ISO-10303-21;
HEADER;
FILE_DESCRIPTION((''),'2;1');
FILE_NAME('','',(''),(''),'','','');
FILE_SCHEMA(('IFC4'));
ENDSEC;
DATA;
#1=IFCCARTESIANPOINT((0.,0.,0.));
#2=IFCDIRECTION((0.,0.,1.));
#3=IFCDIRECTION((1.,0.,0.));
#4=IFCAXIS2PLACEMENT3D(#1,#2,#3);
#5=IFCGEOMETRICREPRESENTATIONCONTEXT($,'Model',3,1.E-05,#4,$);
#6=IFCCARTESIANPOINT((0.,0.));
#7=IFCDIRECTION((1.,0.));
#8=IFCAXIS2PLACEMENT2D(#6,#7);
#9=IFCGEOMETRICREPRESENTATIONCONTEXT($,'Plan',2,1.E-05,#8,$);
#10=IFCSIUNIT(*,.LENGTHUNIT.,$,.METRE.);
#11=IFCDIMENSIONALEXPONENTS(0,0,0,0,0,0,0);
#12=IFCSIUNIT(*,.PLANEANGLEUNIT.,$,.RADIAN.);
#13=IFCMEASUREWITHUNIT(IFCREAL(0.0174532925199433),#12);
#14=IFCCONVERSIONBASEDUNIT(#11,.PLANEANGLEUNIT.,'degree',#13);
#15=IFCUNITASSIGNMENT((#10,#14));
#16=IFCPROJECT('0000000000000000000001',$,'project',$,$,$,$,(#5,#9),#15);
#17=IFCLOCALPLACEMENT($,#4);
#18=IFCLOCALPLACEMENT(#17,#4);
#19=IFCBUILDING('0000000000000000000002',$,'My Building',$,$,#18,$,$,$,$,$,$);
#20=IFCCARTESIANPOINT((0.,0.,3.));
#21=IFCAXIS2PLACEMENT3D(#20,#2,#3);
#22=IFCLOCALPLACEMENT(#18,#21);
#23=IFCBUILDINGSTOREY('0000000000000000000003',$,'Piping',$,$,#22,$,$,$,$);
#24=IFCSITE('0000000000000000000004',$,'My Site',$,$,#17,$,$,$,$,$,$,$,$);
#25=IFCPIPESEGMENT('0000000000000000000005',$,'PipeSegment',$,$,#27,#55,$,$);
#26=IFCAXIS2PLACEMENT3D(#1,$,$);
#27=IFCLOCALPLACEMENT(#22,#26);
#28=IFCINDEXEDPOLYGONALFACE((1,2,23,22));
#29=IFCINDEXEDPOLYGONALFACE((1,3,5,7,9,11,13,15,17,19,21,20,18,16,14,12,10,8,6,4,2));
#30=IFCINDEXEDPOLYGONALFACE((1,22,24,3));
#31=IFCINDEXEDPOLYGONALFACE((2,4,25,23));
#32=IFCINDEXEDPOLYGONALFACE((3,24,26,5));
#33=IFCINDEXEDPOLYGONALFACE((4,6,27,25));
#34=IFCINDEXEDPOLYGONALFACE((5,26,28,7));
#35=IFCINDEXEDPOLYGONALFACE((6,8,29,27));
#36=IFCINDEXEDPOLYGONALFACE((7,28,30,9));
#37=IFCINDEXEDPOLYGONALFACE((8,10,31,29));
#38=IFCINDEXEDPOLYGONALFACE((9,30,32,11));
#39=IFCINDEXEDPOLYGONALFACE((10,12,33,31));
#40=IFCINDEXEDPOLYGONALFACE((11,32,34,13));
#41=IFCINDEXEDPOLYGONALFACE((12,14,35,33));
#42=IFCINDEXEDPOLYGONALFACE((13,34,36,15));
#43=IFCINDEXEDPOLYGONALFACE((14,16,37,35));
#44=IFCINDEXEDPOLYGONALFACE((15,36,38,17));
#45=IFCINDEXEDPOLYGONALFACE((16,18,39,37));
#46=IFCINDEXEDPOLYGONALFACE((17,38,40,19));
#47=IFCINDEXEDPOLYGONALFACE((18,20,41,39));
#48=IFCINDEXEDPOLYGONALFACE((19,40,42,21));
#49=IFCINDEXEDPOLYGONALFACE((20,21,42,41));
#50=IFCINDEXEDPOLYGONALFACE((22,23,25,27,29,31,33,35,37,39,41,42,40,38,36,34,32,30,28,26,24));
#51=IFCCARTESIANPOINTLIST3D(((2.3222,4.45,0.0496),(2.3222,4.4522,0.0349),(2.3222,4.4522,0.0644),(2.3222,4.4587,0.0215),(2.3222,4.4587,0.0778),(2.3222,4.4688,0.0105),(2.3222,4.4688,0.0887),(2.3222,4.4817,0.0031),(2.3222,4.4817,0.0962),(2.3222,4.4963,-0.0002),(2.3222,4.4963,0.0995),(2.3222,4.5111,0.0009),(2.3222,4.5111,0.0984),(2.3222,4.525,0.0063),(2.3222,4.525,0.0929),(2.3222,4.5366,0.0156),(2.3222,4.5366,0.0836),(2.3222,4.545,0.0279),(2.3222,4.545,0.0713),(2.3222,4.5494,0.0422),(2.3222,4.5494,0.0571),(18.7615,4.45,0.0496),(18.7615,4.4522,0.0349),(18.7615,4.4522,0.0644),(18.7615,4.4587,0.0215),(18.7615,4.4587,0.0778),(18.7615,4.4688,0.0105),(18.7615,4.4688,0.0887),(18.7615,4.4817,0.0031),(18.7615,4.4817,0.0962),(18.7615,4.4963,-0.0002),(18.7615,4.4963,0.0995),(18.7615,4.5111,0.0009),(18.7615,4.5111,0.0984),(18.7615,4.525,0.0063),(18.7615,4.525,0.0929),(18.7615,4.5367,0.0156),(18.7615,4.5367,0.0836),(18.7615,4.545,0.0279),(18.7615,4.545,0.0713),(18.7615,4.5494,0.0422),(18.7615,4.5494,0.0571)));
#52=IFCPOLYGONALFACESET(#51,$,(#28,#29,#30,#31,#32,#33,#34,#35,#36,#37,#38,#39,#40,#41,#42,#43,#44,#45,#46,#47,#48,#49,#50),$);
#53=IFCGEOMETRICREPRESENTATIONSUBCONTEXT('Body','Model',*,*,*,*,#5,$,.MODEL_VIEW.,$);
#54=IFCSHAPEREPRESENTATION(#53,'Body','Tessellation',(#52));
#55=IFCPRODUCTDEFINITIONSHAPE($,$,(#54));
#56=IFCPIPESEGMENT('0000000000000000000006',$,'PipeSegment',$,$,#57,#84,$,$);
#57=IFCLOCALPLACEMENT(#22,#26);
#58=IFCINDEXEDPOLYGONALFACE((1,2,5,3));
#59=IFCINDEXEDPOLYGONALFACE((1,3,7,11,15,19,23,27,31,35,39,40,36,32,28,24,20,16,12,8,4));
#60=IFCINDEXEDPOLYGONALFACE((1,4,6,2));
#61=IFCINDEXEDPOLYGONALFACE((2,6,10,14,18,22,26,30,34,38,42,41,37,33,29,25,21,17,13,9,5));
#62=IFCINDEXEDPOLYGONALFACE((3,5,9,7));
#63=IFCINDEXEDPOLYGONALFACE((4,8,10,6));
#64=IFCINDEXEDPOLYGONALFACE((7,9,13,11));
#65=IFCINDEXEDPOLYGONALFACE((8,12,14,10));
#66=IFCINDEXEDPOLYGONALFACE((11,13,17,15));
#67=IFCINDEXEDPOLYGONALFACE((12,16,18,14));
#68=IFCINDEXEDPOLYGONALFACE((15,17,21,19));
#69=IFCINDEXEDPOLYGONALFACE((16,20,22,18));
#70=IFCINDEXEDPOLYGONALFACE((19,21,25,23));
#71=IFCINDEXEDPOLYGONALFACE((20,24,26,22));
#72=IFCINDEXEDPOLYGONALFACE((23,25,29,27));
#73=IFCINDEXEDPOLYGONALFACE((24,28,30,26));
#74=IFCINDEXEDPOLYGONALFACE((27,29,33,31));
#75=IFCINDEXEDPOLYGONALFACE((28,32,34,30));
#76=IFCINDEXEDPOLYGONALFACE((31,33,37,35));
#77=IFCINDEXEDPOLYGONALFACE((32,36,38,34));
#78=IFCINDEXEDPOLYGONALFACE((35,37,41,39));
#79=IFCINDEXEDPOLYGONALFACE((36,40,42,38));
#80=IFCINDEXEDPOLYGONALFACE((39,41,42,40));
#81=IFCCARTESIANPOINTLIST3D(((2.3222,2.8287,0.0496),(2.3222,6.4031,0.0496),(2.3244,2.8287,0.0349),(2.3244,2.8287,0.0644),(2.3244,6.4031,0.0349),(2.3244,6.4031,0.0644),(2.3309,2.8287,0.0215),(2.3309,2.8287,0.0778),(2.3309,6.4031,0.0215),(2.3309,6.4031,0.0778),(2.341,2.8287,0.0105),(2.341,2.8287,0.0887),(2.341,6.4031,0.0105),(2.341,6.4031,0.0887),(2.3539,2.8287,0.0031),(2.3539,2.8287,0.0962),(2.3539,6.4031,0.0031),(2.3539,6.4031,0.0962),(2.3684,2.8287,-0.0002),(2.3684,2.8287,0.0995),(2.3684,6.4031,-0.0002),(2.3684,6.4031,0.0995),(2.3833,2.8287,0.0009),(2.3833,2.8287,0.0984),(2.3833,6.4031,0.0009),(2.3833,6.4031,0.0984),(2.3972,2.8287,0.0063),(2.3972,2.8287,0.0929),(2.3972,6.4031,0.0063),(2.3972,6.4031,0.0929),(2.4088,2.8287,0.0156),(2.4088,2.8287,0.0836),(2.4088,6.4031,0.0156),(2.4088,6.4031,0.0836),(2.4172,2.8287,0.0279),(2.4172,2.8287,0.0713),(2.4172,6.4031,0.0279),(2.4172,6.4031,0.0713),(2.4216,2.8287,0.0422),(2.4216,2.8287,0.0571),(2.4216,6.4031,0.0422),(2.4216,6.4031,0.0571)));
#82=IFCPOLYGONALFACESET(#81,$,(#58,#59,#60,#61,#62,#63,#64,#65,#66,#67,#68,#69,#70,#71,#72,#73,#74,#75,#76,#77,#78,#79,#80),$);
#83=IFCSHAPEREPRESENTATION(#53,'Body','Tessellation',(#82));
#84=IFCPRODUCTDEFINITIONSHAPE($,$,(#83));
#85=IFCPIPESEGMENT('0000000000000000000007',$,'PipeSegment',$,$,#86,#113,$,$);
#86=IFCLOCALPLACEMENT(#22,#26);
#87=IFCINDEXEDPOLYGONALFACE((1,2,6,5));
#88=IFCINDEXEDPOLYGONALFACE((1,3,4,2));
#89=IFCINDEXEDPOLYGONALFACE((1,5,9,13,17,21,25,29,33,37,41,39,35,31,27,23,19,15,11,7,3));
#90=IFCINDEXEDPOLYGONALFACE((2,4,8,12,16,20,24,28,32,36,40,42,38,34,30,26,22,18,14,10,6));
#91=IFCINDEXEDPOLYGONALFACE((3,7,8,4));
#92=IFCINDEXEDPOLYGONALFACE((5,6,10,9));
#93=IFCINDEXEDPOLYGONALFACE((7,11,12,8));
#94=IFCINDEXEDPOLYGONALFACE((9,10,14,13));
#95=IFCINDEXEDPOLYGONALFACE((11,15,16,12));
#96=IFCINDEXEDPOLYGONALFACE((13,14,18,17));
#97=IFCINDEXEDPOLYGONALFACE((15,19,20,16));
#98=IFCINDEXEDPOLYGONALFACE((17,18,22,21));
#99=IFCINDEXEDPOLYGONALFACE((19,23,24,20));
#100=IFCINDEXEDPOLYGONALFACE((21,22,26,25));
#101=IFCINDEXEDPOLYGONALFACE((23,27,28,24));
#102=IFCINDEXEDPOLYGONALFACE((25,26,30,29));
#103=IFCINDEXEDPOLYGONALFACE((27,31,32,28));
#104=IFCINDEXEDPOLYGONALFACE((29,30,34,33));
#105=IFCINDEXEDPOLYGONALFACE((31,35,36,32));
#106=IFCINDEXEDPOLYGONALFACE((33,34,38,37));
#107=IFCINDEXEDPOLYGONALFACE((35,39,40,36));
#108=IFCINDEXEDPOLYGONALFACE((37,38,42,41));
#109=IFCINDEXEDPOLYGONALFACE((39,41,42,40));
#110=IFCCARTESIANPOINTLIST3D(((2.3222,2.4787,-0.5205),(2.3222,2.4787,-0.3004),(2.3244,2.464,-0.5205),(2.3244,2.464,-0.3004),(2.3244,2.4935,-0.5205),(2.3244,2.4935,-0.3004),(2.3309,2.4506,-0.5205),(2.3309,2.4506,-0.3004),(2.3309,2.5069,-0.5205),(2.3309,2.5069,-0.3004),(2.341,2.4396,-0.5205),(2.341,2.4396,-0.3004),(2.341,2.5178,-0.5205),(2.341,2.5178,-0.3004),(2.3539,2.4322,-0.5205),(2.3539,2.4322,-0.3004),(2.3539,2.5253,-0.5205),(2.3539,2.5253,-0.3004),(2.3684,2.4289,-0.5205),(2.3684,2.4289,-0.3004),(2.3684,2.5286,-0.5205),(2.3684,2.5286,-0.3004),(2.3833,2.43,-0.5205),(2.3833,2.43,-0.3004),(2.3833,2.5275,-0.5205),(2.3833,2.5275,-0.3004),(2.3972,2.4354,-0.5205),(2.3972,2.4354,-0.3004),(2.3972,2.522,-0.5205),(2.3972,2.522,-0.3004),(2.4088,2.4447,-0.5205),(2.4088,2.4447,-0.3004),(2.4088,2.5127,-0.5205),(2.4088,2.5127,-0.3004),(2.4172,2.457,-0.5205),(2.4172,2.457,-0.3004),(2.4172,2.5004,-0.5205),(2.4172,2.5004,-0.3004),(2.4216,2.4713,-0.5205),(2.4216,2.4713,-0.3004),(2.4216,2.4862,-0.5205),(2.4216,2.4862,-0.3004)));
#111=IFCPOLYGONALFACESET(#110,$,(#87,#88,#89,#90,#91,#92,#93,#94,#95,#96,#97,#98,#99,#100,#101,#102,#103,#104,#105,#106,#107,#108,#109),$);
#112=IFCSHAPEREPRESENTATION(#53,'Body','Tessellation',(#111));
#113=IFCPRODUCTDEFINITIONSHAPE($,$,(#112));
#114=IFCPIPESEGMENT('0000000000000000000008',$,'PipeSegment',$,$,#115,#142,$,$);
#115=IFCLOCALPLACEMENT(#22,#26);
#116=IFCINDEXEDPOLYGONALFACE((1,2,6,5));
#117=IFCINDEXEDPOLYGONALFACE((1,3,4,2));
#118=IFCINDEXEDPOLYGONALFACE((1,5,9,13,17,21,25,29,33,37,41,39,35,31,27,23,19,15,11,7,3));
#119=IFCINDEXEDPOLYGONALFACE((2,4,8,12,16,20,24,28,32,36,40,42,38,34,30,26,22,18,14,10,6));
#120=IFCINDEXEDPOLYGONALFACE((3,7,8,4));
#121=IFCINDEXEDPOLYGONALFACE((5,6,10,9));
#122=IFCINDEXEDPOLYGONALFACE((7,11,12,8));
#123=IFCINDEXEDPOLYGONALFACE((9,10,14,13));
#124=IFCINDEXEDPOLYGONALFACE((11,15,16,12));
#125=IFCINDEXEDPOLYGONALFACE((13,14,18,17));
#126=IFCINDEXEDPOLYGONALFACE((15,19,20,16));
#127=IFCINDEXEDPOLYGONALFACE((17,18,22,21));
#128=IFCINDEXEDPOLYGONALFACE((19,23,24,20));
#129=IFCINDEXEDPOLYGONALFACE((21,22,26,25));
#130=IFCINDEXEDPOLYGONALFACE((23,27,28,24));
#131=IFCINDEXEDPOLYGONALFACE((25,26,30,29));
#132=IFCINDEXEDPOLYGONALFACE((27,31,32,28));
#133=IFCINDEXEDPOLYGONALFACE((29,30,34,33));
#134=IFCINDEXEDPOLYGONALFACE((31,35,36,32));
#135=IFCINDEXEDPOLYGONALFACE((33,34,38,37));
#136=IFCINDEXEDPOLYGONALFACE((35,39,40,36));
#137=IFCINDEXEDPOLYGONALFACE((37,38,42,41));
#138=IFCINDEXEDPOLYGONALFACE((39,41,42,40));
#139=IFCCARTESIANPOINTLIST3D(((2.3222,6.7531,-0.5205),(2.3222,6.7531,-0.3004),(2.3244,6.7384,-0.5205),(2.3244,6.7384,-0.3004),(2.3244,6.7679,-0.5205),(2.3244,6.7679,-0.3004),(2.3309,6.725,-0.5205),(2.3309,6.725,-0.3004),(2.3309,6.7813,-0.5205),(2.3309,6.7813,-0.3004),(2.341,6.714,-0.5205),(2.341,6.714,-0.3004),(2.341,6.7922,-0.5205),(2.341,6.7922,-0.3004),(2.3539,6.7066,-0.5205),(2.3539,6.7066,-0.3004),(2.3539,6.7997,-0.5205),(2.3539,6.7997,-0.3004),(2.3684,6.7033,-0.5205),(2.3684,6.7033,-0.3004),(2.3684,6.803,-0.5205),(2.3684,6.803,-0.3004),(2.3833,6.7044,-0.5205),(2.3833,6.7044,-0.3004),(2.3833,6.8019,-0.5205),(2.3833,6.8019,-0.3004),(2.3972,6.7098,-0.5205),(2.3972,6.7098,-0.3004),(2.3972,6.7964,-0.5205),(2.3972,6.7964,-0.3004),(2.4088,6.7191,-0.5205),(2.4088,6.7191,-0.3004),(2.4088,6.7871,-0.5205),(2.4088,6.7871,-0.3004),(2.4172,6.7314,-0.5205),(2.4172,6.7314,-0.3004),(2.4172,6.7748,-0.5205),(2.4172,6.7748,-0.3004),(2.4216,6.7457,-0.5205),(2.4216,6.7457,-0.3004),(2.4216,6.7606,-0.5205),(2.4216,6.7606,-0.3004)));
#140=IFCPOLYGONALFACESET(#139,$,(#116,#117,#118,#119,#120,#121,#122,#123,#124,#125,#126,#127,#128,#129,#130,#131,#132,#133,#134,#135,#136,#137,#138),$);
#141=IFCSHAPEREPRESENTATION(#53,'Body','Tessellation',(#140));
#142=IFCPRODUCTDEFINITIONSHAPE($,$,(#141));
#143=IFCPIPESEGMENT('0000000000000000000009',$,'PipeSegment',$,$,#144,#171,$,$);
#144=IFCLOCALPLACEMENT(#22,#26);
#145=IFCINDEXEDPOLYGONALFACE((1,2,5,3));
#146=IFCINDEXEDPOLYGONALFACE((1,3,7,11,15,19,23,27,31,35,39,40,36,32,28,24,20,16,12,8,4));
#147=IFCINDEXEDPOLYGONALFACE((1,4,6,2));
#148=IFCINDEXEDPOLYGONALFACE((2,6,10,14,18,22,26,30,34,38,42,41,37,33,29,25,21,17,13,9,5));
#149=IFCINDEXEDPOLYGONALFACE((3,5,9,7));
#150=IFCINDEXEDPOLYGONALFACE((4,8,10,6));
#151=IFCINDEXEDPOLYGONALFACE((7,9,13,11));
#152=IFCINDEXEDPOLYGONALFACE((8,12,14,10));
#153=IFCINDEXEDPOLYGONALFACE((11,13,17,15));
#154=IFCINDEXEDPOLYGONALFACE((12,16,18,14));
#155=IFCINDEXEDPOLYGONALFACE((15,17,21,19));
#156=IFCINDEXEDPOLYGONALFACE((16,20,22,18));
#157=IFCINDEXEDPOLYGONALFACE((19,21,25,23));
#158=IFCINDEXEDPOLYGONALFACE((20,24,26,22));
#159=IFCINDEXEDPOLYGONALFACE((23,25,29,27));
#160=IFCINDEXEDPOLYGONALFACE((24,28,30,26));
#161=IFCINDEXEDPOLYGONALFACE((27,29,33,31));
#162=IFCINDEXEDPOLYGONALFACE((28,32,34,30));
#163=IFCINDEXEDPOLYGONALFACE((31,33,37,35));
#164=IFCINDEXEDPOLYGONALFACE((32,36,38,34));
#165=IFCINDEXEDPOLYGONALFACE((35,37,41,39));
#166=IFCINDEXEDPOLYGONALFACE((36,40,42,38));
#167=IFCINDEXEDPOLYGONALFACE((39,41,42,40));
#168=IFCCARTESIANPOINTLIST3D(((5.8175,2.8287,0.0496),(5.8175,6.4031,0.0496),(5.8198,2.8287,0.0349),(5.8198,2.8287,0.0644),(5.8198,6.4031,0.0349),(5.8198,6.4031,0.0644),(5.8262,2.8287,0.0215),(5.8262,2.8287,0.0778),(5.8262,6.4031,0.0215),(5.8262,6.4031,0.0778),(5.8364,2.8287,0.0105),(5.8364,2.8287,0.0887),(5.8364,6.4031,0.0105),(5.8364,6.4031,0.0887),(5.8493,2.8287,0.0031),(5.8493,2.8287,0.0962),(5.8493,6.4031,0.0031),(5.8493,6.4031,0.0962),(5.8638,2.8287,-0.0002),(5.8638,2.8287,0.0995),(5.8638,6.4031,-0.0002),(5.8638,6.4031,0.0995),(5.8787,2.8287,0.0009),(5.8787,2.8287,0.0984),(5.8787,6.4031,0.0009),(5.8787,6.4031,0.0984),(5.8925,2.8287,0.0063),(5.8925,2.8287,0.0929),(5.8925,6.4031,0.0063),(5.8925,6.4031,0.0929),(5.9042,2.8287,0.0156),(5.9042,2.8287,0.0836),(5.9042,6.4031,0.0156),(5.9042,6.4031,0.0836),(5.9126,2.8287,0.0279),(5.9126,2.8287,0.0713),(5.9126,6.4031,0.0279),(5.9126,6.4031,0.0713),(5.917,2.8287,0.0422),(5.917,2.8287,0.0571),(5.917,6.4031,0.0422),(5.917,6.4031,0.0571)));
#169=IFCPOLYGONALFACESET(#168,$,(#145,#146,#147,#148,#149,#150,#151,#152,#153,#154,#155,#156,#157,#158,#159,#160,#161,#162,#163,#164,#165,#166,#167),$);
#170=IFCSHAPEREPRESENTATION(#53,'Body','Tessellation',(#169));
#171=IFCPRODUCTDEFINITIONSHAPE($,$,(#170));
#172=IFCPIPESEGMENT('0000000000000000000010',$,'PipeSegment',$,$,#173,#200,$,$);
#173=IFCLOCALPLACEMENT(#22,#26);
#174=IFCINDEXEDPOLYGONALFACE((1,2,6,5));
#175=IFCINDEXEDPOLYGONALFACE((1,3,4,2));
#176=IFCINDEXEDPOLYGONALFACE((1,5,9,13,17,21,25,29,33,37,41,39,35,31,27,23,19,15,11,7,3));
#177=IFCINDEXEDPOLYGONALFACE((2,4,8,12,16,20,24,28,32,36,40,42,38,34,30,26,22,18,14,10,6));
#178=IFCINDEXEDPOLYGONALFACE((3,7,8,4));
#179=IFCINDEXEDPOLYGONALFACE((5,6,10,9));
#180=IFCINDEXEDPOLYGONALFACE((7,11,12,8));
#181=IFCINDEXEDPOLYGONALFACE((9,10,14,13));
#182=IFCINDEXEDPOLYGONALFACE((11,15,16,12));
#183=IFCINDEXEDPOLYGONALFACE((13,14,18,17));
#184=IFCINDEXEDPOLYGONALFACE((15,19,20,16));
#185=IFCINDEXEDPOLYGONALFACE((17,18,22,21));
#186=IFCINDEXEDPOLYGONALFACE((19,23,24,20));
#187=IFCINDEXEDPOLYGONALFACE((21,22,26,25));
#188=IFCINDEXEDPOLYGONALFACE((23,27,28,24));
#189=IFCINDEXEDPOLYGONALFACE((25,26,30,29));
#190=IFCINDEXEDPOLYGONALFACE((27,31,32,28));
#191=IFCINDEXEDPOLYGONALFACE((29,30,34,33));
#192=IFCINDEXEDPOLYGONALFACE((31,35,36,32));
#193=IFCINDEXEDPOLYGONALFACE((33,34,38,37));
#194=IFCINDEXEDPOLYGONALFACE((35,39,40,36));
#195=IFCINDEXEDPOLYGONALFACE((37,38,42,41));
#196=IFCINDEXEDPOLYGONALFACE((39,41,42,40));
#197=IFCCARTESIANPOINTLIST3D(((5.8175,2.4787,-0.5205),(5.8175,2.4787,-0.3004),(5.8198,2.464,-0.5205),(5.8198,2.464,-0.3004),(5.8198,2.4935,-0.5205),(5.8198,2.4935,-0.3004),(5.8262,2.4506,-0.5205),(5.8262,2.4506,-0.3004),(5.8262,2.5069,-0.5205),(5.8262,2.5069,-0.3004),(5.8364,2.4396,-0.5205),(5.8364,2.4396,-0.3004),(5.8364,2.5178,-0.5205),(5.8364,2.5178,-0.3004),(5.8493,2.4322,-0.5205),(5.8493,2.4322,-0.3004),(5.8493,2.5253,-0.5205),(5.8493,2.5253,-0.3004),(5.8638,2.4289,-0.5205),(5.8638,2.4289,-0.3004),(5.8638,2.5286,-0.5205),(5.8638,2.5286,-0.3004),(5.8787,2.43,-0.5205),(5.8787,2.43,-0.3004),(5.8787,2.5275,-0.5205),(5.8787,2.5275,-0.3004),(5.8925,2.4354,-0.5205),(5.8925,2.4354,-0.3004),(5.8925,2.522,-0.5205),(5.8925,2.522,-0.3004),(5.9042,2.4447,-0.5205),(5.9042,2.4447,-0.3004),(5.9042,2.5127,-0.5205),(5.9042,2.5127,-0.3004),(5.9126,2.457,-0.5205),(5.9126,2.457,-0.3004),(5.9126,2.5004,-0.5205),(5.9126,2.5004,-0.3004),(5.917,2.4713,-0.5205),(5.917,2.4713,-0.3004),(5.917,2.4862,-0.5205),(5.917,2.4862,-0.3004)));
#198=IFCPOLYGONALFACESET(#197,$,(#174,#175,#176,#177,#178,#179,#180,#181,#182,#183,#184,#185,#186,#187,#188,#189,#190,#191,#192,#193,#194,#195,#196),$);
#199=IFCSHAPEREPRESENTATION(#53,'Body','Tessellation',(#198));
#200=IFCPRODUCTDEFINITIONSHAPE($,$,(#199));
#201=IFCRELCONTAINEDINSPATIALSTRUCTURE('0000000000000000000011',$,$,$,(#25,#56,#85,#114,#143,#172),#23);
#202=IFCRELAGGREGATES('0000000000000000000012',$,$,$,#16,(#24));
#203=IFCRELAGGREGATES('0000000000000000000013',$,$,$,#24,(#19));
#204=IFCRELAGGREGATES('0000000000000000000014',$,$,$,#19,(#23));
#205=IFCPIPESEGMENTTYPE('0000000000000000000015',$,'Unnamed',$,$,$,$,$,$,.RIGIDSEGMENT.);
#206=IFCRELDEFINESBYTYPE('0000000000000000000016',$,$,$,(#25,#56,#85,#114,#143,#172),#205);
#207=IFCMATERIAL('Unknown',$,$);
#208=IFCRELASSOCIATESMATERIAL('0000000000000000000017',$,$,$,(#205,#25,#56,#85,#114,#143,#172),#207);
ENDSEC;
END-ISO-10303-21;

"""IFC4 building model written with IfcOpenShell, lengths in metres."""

from ifc_helpers import new_model, entity, si_unit, converted_unit, frame, origin_with_axes, origin_2d_with_axis, place, context, subcontext, project, spatial, circle, extrude, material, material_profile, profile_set, profile_usage, type_object, element, save


model = new_model("IFC4")

# Units and contexts
model_context = context("Model", 3, precision=1e-05, world=origin_with_axes())
plan_context = context("Plan", 2, precision=1e-05, world=origin_2d_with_axis())
body_context = subcontext(model_context, "Body", "Model", "MODEL_VIEW")
ifc_project = project(units=[si_unit("LENGTHUNIT", "METRE"), converted_unit("PLANEANGLEUNIT", "degree", entity("IfcReal", 0.0174532925199433), si_unit("PLANEANGLEUNIT", "RADIAN"), dimensions=[0, 0, 0, 0, 0, 0, 0])], contexts=[model_context, plan_context])

# Site, building, storey
site_placement = place(None, origin_with_axes())
site = spatial("IfcSite", under=ifc_project, at=site_placement, Name="My Site")
building_placement = place(site_placement, origin_with_axes())
building = spatial("IfcBuilding", under=site, at=building_placement, Name="My Building")
storey_placement = place(building_placement, frame((0.0, 0.0, 3.0), z_axis=(0.0, 0.0, 1.0), x_axis=(1.0, 0.0, 0.0)))
storey = spatial("IfcBuildingStorey", under=building, at=storey_placement, Name="Piping")

# Pipe segments
ifc_material = material(Name="Unknown")
ifc_material_profile = material_profile(ifc_material, circle(Radius=0.05))
ifc_profile_set = profile_set([ifc_material_profile])
ifc_profile_usage_1 = profile_usage(ifc_profile_set, cardinal=5)
pipe_segment_type = type_object("IfcPipeSegmentType", Name="Unnamed", PredefinedType="RIGIDSEGMENT", material=ifc_profile_set)
pipe_segment_1_placement = place(storey_placement, frame((18.7615, 4.5, 0.0496), z_axis=(-1.0, 0.0, 0.0), x_axis=(0.0, -1.0, 0.0)))
element("IfcPipeSegment", 1, at=pipe_segment_1_placement, inside=storey, type_object=pipe_segment_type, material=ifc_profile_usage_1, Name="PipeSegment", context=body_context, shape_type="SweptSolid", body=[
    extrude(circle(Radius=0.05), origin_with_axes(), (0.0, 0.0, 1.0), 16.4393),
])
ifc_profile_usage_2 = profile_usage(ifc_profile_set, cardinal=5)
pipe_segment_2_placement = place(storey_placement, frame((2.3722, 2.8287, 0.0496), z_axis=(0.0, 1.0, 0.0), x_axis=(-1.0, 0.0, 0.0)))
element("IfcPipeSegment", 2, at=pipe_segment_2_placement, inside=storey, type_object=pipe_segment_type, material=ifc_profile_usage_2, Name="PipeSegment", context=body_context, shape_type="SweptSolid", body=[
    extrude(circle(Radius=0.05), origin_with_axes(), (0.0, 0.0, 1.0), 3.5744),
])
ifc_profile_usage_3 = profile_usage(ifc_profile_set, cardinal=5)
pipe_segment_3_placement = place(storey_placement, frame((2.3722, 2.4787, -0.3004), z_axis=(0.0, 0.0, -1.0), x_axis=(-1.0, 0.0, 0.0)))
element("IfcPipeSegment", 3, at=pipe_segment_3_placement, inside=storey, type_object=pipe_segment_type, material=ifc_profile_usage_3, Name="PipeSegment", context=body_context, shape_type="SweptSolid", body=[
    extrude(circle(Radius=0.05), origin_with_axes(), (0.0, 0.0, 1.0), 0.2201),
])
ifc_profile_usage_4 = profile_usage(ifc_profile_set, cardinal=5)
pipe_segment_4_placement = place(storey_placement, frame((2.3722, 6.7531, -0.3004), z_axis=(0.0, 0.0, -1.0), x_axis=(-1.0, 0.0, 0.0)))
element("IfcPipeSegment", 4, at=pipe_segment_4_placement, inside=storey, type_object=pipe_segment_type, material=ifc_profile_usage_4, Name="PipeSegment", context=body_context, shape_type="SweptSolid", body=[
    extrude(circle(Radius=0.05), origin_with_axes(), (0.0, 0.0, 1.0), 0.2201),
])
ifc_profile_usage_5 = profile_usage(ifc_profile_set, cardinal=5)
pipe_segment_5_placement = place(storey_placement, frame((5.8675, 2.8287, 0.0496), z_axis=(0.0, 1.0, 0.0), x_axis=(-1.0, 0.0, 0.0)))
element("IfcPipeSegment", 5, at=pipe_segment_5_placement, inside=storey, type_object=pipe_segment_type, material=ifc_profile_usage_5, Name="PipeSegment", context=body_context, shape_type="SweptSolid", body=[
    extrude(circle(Radius=0.05), origin_with_axes(), (0.0, 0.0, 1.0), 3.5744),
])
ifc_profile_usage_6 = profile_usage(ifc_profile_set, cardinal=5)
pipe_segment_6_placement = place(storey_placement, frame((5.8675, 2.4787, -0.3004), z_axis=(0.0, 0.0, -1.0), x_axis=(-1.0, 0.0, 0.0)))
element("IfcPipeSegment", 6, at=pipe_segment_6_placement, inside=storey, type_object=pipe_segment_type, material=ifc_profile_usage_6, Name="PipeSegment", context=body_context, shape_type="SweptSolid", body=[
    extrude(circle(Radius=0.05), origin_with_axes(), (0.0, 0.0, 1.0), 0.2201),
])

save(model, "model.ifc")
